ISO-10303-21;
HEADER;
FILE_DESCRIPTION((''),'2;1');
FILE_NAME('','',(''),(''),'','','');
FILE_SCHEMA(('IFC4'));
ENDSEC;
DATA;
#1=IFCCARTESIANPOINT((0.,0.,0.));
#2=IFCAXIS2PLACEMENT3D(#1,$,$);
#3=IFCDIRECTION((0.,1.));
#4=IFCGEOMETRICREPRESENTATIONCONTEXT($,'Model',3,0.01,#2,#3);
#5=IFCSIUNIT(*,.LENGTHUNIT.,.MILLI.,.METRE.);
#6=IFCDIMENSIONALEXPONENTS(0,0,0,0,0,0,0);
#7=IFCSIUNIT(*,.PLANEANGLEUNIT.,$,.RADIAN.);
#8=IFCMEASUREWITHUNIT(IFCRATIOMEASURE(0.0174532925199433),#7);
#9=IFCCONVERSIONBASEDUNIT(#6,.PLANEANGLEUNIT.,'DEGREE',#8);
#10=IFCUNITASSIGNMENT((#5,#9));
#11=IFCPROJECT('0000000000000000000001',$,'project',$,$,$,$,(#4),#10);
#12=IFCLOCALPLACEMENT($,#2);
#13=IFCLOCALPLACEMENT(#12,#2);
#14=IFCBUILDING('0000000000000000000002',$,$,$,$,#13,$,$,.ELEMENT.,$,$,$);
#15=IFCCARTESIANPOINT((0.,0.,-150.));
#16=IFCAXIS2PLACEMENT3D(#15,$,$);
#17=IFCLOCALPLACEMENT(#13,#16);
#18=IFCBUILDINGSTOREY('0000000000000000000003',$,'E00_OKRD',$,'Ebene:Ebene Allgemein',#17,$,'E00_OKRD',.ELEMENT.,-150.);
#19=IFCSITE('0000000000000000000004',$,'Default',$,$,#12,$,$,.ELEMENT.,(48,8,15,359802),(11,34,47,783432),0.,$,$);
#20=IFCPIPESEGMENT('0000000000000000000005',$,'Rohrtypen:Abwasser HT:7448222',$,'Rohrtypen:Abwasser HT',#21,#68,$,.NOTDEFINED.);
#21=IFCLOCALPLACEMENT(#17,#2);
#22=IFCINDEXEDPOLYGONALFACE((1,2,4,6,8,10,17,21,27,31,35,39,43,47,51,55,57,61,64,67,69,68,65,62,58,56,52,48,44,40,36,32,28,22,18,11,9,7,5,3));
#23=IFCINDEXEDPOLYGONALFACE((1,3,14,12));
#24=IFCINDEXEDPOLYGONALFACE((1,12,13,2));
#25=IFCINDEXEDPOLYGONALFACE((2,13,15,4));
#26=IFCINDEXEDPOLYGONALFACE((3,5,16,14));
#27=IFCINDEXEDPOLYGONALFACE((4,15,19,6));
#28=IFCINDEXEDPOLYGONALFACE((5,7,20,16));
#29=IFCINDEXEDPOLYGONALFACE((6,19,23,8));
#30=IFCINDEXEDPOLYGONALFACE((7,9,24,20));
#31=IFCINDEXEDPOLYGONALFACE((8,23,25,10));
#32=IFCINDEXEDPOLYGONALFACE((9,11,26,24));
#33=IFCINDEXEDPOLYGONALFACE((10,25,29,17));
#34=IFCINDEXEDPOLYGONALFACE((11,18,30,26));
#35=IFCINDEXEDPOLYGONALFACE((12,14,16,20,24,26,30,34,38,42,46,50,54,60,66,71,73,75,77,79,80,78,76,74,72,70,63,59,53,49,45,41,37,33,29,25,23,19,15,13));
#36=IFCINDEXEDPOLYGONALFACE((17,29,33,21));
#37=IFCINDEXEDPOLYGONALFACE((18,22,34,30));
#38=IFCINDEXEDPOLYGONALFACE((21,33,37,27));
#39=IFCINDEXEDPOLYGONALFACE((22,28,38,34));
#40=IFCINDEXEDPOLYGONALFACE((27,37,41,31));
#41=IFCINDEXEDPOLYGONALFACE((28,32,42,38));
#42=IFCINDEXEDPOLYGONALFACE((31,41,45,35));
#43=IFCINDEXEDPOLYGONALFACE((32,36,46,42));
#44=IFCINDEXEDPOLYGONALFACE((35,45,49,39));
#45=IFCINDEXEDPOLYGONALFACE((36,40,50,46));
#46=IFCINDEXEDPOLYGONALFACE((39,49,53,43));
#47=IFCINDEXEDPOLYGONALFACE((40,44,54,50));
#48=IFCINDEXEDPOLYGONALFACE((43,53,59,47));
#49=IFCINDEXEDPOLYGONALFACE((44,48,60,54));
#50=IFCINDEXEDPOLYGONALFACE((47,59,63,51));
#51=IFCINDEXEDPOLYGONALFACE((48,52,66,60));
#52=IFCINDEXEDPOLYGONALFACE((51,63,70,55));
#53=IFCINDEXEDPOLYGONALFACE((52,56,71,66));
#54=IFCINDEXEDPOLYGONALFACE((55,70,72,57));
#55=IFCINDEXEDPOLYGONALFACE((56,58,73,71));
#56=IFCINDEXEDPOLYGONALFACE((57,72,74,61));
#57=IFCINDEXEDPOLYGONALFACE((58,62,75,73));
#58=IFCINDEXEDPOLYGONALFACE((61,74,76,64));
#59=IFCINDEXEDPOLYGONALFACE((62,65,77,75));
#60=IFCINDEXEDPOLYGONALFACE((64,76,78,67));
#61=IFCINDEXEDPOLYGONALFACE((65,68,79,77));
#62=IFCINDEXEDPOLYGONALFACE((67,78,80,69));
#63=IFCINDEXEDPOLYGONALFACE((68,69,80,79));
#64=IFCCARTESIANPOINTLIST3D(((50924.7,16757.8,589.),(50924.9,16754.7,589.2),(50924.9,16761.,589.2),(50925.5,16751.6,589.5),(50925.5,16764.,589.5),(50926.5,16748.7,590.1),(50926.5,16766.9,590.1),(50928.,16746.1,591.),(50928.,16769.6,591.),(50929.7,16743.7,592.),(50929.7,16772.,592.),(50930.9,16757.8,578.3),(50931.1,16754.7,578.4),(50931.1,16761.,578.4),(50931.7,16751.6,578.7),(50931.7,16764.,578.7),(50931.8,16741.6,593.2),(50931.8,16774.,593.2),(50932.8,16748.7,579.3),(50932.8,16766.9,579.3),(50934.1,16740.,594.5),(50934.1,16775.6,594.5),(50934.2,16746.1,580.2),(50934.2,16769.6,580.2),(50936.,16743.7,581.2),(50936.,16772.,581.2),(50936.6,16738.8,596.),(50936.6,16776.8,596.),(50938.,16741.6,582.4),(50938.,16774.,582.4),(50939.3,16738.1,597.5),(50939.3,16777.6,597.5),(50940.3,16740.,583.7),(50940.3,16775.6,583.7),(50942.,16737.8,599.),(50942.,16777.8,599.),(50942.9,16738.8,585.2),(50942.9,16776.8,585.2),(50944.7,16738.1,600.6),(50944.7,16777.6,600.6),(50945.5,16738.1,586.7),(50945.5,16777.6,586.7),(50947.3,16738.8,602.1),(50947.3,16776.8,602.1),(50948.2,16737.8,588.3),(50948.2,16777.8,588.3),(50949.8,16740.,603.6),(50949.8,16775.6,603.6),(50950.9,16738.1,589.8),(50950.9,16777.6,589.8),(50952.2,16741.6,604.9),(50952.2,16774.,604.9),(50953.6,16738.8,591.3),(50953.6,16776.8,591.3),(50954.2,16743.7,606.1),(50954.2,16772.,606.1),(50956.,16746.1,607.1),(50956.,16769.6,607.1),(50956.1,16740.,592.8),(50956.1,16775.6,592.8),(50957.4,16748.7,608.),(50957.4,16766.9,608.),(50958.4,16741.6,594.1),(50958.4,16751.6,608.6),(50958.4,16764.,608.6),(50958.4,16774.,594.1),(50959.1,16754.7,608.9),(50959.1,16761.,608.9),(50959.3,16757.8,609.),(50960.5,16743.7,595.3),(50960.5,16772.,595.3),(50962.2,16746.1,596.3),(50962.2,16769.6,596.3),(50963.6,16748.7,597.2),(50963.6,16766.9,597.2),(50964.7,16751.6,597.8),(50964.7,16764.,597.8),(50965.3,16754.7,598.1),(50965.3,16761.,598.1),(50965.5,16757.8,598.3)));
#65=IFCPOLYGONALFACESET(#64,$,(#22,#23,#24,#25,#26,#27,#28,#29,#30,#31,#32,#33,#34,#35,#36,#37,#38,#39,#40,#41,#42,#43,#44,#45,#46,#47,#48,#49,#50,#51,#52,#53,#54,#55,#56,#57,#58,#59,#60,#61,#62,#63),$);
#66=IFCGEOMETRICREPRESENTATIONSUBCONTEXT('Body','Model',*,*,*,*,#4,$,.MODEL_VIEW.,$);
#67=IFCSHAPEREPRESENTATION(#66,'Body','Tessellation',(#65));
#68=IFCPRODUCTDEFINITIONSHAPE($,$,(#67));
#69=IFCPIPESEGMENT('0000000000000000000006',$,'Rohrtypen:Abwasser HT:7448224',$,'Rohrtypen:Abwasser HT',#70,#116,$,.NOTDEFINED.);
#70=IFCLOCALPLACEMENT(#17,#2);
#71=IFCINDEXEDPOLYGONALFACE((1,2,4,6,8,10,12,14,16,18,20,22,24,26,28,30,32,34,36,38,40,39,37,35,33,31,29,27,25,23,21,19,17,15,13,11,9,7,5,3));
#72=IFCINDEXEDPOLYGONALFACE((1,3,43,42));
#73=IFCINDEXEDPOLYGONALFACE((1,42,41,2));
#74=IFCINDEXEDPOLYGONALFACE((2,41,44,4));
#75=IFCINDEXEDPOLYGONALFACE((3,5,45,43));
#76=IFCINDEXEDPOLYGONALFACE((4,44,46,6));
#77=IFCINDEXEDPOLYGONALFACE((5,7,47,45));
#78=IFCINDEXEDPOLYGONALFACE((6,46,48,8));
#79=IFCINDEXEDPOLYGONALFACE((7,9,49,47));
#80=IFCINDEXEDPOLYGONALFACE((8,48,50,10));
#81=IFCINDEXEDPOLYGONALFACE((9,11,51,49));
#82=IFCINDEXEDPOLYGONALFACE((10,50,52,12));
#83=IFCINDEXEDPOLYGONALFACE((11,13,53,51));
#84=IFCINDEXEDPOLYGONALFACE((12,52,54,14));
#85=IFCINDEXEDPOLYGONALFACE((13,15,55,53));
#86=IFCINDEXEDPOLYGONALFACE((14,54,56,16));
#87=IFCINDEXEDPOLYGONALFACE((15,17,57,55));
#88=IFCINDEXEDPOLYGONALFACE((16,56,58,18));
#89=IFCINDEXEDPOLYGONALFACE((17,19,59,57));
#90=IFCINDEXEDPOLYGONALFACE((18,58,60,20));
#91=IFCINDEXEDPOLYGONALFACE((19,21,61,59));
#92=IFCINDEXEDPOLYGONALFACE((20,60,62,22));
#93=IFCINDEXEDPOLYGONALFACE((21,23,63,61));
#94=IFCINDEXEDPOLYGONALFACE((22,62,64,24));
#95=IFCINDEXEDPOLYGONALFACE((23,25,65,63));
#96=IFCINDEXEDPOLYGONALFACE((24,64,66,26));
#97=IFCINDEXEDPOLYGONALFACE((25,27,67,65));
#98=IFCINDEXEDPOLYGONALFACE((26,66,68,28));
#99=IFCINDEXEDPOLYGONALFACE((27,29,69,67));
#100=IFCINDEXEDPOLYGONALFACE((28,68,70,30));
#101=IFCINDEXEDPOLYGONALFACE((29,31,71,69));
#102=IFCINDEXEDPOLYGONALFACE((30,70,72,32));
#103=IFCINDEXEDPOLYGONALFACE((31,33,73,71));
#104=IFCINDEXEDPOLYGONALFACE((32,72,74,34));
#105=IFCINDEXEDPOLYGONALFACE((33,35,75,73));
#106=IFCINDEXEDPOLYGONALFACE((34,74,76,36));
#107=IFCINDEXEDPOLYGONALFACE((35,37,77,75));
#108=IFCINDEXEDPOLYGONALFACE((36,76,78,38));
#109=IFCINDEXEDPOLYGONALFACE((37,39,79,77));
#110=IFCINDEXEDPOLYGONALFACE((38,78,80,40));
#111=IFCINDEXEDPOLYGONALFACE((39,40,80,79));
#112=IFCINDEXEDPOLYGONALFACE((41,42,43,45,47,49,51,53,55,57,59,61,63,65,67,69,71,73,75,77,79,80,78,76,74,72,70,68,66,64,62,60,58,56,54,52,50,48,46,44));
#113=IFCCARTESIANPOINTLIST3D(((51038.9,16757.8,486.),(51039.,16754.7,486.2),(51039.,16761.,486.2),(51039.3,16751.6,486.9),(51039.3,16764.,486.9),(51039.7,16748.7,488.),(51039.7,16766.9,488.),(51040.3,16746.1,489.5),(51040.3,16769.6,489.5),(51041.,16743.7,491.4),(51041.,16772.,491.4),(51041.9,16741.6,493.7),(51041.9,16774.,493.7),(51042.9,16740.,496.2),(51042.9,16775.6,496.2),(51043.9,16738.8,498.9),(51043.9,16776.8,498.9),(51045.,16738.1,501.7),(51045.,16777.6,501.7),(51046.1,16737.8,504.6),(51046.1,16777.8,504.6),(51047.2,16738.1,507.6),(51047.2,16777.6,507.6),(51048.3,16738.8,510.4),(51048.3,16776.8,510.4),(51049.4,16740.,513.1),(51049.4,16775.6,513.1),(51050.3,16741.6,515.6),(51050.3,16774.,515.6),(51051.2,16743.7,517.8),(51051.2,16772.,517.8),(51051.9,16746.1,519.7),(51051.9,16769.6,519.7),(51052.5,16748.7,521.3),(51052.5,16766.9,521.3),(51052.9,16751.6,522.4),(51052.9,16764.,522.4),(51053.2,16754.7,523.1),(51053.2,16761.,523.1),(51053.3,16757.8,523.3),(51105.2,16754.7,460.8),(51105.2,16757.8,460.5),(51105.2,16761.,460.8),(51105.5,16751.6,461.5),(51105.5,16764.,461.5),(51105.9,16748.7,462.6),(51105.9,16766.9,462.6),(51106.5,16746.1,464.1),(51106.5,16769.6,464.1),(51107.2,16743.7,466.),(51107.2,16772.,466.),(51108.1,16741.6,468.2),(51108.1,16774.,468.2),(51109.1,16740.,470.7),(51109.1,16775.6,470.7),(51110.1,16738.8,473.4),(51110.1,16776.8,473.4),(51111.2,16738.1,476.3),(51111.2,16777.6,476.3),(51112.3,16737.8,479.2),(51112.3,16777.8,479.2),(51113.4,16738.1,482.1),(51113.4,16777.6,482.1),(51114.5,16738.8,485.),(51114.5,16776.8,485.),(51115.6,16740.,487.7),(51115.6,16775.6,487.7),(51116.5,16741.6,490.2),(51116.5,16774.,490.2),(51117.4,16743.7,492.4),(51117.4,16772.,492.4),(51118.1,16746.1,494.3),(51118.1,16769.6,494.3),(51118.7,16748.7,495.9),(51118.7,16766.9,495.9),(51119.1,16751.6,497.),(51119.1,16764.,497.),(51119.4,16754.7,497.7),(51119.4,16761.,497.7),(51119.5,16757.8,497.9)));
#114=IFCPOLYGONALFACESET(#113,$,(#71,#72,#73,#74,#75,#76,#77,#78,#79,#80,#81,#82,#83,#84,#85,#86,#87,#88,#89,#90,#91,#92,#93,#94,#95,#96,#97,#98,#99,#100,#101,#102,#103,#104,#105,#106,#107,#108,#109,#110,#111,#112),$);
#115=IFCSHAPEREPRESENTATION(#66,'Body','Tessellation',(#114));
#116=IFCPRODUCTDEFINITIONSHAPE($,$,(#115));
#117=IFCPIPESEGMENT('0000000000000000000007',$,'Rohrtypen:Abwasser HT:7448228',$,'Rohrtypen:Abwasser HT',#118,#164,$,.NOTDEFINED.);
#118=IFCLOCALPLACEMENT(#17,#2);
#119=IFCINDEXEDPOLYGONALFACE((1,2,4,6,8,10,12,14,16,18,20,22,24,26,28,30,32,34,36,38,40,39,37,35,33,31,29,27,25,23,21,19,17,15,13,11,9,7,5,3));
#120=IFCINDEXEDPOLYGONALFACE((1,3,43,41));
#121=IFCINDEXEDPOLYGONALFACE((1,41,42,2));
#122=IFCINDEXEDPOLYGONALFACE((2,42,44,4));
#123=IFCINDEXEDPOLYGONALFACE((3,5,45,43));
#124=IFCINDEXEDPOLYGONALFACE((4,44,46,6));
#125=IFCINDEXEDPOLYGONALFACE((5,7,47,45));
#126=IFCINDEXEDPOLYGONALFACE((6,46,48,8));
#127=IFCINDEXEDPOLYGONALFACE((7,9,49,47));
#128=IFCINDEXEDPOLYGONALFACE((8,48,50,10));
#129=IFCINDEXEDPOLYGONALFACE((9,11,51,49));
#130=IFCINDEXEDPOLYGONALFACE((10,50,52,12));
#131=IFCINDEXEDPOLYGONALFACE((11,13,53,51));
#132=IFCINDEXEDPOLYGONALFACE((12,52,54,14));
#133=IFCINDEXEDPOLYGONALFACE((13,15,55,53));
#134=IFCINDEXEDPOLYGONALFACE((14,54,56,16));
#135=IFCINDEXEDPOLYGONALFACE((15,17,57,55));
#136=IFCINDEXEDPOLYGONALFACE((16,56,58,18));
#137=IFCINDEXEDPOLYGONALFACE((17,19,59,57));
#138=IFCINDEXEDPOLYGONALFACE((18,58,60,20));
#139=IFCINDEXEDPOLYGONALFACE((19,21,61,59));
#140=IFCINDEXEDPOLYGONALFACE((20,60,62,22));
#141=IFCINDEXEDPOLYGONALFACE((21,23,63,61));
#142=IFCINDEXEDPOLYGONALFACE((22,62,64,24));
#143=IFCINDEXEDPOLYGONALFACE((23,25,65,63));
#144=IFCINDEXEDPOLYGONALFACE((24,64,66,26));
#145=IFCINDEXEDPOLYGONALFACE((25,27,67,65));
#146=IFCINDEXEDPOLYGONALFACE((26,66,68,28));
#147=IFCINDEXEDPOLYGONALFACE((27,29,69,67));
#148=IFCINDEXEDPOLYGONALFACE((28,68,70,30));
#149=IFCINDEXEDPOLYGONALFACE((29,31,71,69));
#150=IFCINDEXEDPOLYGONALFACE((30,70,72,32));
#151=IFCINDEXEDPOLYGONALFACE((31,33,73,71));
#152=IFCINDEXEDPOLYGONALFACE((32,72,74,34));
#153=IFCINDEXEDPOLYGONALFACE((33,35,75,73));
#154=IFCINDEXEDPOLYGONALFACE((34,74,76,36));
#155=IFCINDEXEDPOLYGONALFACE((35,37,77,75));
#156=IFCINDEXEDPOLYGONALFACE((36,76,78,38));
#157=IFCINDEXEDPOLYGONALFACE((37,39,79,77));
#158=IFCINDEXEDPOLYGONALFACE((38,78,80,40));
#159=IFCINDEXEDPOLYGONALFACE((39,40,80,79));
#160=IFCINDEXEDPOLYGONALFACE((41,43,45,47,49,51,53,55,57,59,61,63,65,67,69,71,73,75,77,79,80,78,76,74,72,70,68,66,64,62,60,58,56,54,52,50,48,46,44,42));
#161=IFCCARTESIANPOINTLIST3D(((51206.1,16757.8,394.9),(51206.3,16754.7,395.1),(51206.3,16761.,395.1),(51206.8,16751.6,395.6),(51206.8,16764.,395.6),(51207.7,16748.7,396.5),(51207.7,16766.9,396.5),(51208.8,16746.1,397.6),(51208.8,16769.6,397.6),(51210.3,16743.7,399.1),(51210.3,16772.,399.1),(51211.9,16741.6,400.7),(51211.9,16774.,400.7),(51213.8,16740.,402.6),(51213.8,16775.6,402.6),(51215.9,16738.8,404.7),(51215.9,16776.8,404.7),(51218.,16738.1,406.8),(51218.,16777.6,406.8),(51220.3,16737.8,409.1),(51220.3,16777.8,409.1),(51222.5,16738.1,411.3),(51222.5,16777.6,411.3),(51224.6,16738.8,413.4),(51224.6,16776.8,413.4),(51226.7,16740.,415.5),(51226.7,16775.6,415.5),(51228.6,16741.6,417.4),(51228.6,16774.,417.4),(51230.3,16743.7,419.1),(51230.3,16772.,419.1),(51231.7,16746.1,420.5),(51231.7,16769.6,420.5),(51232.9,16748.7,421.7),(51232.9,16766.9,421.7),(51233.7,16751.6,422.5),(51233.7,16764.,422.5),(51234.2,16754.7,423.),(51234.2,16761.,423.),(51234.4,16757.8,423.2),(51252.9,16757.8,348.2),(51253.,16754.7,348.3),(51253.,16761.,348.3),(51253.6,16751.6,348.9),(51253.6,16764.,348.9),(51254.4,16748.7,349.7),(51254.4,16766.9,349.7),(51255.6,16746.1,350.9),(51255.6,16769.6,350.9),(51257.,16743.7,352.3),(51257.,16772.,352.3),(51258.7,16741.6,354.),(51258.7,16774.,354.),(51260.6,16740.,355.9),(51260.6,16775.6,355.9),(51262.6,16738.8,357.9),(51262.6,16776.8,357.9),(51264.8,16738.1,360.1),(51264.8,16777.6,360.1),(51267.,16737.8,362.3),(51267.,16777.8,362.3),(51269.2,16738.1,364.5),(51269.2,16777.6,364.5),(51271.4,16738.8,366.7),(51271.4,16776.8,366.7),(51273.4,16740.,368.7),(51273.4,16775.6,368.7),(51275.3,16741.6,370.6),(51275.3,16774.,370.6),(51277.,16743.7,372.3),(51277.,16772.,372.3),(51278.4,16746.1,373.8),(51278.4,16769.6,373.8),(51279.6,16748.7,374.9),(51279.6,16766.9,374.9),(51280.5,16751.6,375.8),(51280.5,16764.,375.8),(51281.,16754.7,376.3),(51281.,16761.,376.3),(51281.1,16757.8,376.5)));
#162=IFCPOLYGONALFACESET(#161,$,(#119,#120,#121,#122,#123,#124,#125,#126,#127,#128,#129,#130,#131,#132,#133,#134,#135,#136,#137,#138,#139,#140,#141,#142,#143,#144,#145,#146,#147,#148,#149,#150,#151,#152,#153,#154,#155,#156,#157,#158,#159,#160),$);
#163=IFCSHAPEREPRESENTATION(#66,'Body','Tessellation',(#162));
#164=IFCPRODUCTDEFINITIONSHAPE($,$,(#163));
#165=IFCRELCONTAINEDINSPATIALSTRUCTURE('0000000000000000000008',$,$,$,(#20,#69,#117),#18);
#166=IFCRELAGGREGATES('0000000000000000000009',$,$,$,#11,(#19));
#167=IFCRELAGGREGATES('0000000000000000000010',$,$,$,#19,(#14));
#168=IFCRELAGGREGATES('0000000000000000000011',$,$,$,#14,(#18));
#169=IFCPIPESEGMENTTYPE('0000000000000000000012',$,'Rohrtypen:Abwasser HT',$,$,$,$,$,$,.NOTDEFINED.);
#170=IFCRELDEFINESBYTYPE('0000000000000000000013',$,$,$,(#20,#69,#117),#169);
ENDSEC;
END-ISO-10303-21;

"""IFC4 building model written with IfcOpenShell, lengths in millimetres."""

from ifc_helpers import new_model, entity, si_unit, converted_unit, direction, frame, origin, place, context, subcontext, project, spatial, indexed_curve, outline, extrude, type_object, element, save


model = new_model("IFC4")

# Units and contexts
model_context = context("Model", 3, precision=0.01, world=origin(), true_north=direction((0.0, 1.0)))
body_context = subcontext(model_context, "Body", "Model", "MODEL_VIEW")
ifc_project = project(units=[si_unit("LENGTHUNIT", "METRE", prefix="MILLI"), converted_unit("PLANEANGLEUNIT", "DEGREE", entity("IfcRatioMeasure", 0.0174532925199433), si_unit("PLANEANGLEUNIT", "RADIAN"), dimensions=[0, 0, 0, 0, 0, 0, 0])], contexts=[model_context])

# Site, building, storey
site_placement = place(None, origin())
site = spatial("IfcSite", under=ifc_project, at=site_placement, Name="Default", CompositionType="ELEMENT", RefLatitude=(48, 8, 15, 359802), RefLongitude=(11, 34, 47, 783432), RefElevation=0.0)
building_placement = place(site_placement, origin())
building = spatial("IfcBuilding", under=site, at=building_placement, CompositionType="ELEMENT")
storey_placement = place(building_placement, frame((0.0, 0.0, -150.0)))
storey = spatial("IfcBuildingStorey", under=building, at=storey_placement, Name="E00_OKRD", ObjectType="Ebene:Ebene Allgemein", LongName="E00_OKRD", CompositionType="ELEMENT", Elevation=-150.0)

# Pipe segments
pipe_segment_type_1 = type_object("IfcPipeSegmentType", Name="Rohrtypen:Abwasser HT", PredefinedType="NOTDEFINED")
pipe_segment_1_placement = place(storey_placement, origin())
element("IfcPipeSegment", 1, at=pipe_segment_1_placement, inside=storey, type_object=pipe_segment_type_1, Name="Rohrtypen:Abwasser HT:7448222", ObjectType="Rohrtypen:Abwasser HT", PredefinedType="NOTDEFINED", context=body_context, shape_type="SweptSolid", body=[
    extrude(outline(indexed_curve([(20.0, 0.0), (19.8, 3.1), (19.0, 6.2), (17.8, 9.1), (16.2, 11.8), (14.1, 14.1), (11.8, 16.2), (9.1, 17.8), (6.2, 19.0), (3.1, 19.8), (0.0, 20.0), (-3.1, 19.8), (-6.2, 19.0), (-9.1, 17.8), (-11.8, 16.2), (-14.1, 14.1), (-16.2, 11.8), (-17.8, 9.1), (-19.0, 6.2), (-19.8, 3.1), (-20.0, 0.0), (-19.8, -3.1), (-19.0, -6.2), (-17.8, -9.1), (-16.2, -11.8), (-14.1, -14.1), (-11.8, -16.2), (-9.1, -17.8), (-6.2, -19.0), (-3.1, -19.8), (0.0, -20.0), (3.1, -19.8), (6.2, -19.0), (9.1, -17.8), (11.8, -16.2), (14.1, -14.1), (16.2, -11.8), (17.8, -9.1), (19.0, -6.2), (19.8, -3.1), (20.0, 0.0)], self_intersect=False)), frame((50942.0, 16757.8, 599.0), z_axis=(0.5, 0.0, -0.866025), x_axis=(0.0, -1.0, 0.0)), (0.0, 0.0, 1.0), 12.5),
])
pipe_segment_2_placement = place(storey_placement, origin())
element("IfcPipeSegment", 2, at=pipe_segment_2_placement, inside=storey, type_object=pipe_segment_type_1, Name="Rohrtypen:Abwasser HT:7448224", ObjectType="Rohrtypen:Abwasser HT", PredefinedType="NOTDEFINED", context=body_context, shape_type="SweptSolid", body=[
    extrude(outline(indexed_curve([(20.0, 0.0), (19.8, 3.1), (19.0, 6.2), (17.8, 9.1), (16.2, 11.8), (14.1, 14.1), (11.8, 16.2), (9.1, 17.8), (6.2, 19.0), (3.1, 19.8), (0.0, 20.0), (-3.1, 19.8), (-6.2, 19.0), (-9.1, 17.8), (-11.8, 16.2), (-14.1, 14.1), (-16.2, 11.8), (-17.8, 9.1), (-19.0, 6.2), (-19.8, 3.1), (-20.0, 0.0), (-19.8, -3.1), (-19.0, -6.2), (-17.8, -9.1), (-16.2, -11.8), (-14.1, -14.1), (-11.8, -16.2), (-9.1, -17.8), (-6.2, -19.0), (-3.1, -19.8), (0.0, -20.0), (3.1, -19.8), (6.2, -19.0), (9.1, -17.8), (11.8, -16.2), (14.1, -14.1), (16.2, -11.8), (17.8, -9.1), (19.0, -6.2), (19.8, -3.1), (20.0, 0.0)], self_intersect=False)), frame((51112.3, 16757.8, 479.2), z_axis=(-0.93358, 0.000003, 0.358368), x_axis=(-0.000003, -1.0, 0.0)), (0.0, 0.0, 1.0), 70.9),
])
pipe_segment_3_placement = place(storey_placement, origin())
element("IfcPipeSegment", 3, at=pipe_segment_3_placement, inside=storey, type_object=pipe_segment_type_1, Name="Rohrtypen:Abwasser HT:7448228", ObjectType="Rohrtypen:Abwasser HT", PredefinedType="NOTDEFINED", context=body_context, shape_type="SweptSolid", body=[
    extrude(outline(indexed_curve([(20.0, 0.0), (19.8, 3.1), (19.0, 6.2), (17.8, 9.1), (16.2, 11.8), (14.1, 14.1), (11.8, 16.2), (9.1, 17.8), (6.2, 19.0), (3.1, 19.8), (0.0, 20.0), (-3.1, 19.8), (-6.2, 19.0), (-9.1, 17.8), (-11.8, 16.2), (-14.1, 14.1), (-16.2, 11.8), (-17.8, 9.1), (-19.0, 6.2), (-19.8, 3.1), (-20.0, 0.0), (-19.8, -3.1), (-19.0, -6.2), (-17.8, -9.1), (-16.2, -11.8), (-14.1, -14.1), (-11.8, -16.2), (-9.1, -17.8), (-6.2, -19.0), (-3.1, -19.8), (0.0, -20.0), (3.1, -19.8), (6.2, -19.0), (9.1, -17.8), (11.8, -16.2), (14.1, -14.1), (16.2, -11.8), (17.8, -9.1), (19.0, -6.2), (19.8, -3.1), (20.0, 0.0)], self_intersect=False)), frame((51220.3, 16757.8, 409.1), z_axis=(0.707107, 0.0, -0.707107), x_axis=(0.0, 1.0, 0.0)), (0.0, 0.0, 1.0), 66.1),
])

save(model, "model.ifc")
